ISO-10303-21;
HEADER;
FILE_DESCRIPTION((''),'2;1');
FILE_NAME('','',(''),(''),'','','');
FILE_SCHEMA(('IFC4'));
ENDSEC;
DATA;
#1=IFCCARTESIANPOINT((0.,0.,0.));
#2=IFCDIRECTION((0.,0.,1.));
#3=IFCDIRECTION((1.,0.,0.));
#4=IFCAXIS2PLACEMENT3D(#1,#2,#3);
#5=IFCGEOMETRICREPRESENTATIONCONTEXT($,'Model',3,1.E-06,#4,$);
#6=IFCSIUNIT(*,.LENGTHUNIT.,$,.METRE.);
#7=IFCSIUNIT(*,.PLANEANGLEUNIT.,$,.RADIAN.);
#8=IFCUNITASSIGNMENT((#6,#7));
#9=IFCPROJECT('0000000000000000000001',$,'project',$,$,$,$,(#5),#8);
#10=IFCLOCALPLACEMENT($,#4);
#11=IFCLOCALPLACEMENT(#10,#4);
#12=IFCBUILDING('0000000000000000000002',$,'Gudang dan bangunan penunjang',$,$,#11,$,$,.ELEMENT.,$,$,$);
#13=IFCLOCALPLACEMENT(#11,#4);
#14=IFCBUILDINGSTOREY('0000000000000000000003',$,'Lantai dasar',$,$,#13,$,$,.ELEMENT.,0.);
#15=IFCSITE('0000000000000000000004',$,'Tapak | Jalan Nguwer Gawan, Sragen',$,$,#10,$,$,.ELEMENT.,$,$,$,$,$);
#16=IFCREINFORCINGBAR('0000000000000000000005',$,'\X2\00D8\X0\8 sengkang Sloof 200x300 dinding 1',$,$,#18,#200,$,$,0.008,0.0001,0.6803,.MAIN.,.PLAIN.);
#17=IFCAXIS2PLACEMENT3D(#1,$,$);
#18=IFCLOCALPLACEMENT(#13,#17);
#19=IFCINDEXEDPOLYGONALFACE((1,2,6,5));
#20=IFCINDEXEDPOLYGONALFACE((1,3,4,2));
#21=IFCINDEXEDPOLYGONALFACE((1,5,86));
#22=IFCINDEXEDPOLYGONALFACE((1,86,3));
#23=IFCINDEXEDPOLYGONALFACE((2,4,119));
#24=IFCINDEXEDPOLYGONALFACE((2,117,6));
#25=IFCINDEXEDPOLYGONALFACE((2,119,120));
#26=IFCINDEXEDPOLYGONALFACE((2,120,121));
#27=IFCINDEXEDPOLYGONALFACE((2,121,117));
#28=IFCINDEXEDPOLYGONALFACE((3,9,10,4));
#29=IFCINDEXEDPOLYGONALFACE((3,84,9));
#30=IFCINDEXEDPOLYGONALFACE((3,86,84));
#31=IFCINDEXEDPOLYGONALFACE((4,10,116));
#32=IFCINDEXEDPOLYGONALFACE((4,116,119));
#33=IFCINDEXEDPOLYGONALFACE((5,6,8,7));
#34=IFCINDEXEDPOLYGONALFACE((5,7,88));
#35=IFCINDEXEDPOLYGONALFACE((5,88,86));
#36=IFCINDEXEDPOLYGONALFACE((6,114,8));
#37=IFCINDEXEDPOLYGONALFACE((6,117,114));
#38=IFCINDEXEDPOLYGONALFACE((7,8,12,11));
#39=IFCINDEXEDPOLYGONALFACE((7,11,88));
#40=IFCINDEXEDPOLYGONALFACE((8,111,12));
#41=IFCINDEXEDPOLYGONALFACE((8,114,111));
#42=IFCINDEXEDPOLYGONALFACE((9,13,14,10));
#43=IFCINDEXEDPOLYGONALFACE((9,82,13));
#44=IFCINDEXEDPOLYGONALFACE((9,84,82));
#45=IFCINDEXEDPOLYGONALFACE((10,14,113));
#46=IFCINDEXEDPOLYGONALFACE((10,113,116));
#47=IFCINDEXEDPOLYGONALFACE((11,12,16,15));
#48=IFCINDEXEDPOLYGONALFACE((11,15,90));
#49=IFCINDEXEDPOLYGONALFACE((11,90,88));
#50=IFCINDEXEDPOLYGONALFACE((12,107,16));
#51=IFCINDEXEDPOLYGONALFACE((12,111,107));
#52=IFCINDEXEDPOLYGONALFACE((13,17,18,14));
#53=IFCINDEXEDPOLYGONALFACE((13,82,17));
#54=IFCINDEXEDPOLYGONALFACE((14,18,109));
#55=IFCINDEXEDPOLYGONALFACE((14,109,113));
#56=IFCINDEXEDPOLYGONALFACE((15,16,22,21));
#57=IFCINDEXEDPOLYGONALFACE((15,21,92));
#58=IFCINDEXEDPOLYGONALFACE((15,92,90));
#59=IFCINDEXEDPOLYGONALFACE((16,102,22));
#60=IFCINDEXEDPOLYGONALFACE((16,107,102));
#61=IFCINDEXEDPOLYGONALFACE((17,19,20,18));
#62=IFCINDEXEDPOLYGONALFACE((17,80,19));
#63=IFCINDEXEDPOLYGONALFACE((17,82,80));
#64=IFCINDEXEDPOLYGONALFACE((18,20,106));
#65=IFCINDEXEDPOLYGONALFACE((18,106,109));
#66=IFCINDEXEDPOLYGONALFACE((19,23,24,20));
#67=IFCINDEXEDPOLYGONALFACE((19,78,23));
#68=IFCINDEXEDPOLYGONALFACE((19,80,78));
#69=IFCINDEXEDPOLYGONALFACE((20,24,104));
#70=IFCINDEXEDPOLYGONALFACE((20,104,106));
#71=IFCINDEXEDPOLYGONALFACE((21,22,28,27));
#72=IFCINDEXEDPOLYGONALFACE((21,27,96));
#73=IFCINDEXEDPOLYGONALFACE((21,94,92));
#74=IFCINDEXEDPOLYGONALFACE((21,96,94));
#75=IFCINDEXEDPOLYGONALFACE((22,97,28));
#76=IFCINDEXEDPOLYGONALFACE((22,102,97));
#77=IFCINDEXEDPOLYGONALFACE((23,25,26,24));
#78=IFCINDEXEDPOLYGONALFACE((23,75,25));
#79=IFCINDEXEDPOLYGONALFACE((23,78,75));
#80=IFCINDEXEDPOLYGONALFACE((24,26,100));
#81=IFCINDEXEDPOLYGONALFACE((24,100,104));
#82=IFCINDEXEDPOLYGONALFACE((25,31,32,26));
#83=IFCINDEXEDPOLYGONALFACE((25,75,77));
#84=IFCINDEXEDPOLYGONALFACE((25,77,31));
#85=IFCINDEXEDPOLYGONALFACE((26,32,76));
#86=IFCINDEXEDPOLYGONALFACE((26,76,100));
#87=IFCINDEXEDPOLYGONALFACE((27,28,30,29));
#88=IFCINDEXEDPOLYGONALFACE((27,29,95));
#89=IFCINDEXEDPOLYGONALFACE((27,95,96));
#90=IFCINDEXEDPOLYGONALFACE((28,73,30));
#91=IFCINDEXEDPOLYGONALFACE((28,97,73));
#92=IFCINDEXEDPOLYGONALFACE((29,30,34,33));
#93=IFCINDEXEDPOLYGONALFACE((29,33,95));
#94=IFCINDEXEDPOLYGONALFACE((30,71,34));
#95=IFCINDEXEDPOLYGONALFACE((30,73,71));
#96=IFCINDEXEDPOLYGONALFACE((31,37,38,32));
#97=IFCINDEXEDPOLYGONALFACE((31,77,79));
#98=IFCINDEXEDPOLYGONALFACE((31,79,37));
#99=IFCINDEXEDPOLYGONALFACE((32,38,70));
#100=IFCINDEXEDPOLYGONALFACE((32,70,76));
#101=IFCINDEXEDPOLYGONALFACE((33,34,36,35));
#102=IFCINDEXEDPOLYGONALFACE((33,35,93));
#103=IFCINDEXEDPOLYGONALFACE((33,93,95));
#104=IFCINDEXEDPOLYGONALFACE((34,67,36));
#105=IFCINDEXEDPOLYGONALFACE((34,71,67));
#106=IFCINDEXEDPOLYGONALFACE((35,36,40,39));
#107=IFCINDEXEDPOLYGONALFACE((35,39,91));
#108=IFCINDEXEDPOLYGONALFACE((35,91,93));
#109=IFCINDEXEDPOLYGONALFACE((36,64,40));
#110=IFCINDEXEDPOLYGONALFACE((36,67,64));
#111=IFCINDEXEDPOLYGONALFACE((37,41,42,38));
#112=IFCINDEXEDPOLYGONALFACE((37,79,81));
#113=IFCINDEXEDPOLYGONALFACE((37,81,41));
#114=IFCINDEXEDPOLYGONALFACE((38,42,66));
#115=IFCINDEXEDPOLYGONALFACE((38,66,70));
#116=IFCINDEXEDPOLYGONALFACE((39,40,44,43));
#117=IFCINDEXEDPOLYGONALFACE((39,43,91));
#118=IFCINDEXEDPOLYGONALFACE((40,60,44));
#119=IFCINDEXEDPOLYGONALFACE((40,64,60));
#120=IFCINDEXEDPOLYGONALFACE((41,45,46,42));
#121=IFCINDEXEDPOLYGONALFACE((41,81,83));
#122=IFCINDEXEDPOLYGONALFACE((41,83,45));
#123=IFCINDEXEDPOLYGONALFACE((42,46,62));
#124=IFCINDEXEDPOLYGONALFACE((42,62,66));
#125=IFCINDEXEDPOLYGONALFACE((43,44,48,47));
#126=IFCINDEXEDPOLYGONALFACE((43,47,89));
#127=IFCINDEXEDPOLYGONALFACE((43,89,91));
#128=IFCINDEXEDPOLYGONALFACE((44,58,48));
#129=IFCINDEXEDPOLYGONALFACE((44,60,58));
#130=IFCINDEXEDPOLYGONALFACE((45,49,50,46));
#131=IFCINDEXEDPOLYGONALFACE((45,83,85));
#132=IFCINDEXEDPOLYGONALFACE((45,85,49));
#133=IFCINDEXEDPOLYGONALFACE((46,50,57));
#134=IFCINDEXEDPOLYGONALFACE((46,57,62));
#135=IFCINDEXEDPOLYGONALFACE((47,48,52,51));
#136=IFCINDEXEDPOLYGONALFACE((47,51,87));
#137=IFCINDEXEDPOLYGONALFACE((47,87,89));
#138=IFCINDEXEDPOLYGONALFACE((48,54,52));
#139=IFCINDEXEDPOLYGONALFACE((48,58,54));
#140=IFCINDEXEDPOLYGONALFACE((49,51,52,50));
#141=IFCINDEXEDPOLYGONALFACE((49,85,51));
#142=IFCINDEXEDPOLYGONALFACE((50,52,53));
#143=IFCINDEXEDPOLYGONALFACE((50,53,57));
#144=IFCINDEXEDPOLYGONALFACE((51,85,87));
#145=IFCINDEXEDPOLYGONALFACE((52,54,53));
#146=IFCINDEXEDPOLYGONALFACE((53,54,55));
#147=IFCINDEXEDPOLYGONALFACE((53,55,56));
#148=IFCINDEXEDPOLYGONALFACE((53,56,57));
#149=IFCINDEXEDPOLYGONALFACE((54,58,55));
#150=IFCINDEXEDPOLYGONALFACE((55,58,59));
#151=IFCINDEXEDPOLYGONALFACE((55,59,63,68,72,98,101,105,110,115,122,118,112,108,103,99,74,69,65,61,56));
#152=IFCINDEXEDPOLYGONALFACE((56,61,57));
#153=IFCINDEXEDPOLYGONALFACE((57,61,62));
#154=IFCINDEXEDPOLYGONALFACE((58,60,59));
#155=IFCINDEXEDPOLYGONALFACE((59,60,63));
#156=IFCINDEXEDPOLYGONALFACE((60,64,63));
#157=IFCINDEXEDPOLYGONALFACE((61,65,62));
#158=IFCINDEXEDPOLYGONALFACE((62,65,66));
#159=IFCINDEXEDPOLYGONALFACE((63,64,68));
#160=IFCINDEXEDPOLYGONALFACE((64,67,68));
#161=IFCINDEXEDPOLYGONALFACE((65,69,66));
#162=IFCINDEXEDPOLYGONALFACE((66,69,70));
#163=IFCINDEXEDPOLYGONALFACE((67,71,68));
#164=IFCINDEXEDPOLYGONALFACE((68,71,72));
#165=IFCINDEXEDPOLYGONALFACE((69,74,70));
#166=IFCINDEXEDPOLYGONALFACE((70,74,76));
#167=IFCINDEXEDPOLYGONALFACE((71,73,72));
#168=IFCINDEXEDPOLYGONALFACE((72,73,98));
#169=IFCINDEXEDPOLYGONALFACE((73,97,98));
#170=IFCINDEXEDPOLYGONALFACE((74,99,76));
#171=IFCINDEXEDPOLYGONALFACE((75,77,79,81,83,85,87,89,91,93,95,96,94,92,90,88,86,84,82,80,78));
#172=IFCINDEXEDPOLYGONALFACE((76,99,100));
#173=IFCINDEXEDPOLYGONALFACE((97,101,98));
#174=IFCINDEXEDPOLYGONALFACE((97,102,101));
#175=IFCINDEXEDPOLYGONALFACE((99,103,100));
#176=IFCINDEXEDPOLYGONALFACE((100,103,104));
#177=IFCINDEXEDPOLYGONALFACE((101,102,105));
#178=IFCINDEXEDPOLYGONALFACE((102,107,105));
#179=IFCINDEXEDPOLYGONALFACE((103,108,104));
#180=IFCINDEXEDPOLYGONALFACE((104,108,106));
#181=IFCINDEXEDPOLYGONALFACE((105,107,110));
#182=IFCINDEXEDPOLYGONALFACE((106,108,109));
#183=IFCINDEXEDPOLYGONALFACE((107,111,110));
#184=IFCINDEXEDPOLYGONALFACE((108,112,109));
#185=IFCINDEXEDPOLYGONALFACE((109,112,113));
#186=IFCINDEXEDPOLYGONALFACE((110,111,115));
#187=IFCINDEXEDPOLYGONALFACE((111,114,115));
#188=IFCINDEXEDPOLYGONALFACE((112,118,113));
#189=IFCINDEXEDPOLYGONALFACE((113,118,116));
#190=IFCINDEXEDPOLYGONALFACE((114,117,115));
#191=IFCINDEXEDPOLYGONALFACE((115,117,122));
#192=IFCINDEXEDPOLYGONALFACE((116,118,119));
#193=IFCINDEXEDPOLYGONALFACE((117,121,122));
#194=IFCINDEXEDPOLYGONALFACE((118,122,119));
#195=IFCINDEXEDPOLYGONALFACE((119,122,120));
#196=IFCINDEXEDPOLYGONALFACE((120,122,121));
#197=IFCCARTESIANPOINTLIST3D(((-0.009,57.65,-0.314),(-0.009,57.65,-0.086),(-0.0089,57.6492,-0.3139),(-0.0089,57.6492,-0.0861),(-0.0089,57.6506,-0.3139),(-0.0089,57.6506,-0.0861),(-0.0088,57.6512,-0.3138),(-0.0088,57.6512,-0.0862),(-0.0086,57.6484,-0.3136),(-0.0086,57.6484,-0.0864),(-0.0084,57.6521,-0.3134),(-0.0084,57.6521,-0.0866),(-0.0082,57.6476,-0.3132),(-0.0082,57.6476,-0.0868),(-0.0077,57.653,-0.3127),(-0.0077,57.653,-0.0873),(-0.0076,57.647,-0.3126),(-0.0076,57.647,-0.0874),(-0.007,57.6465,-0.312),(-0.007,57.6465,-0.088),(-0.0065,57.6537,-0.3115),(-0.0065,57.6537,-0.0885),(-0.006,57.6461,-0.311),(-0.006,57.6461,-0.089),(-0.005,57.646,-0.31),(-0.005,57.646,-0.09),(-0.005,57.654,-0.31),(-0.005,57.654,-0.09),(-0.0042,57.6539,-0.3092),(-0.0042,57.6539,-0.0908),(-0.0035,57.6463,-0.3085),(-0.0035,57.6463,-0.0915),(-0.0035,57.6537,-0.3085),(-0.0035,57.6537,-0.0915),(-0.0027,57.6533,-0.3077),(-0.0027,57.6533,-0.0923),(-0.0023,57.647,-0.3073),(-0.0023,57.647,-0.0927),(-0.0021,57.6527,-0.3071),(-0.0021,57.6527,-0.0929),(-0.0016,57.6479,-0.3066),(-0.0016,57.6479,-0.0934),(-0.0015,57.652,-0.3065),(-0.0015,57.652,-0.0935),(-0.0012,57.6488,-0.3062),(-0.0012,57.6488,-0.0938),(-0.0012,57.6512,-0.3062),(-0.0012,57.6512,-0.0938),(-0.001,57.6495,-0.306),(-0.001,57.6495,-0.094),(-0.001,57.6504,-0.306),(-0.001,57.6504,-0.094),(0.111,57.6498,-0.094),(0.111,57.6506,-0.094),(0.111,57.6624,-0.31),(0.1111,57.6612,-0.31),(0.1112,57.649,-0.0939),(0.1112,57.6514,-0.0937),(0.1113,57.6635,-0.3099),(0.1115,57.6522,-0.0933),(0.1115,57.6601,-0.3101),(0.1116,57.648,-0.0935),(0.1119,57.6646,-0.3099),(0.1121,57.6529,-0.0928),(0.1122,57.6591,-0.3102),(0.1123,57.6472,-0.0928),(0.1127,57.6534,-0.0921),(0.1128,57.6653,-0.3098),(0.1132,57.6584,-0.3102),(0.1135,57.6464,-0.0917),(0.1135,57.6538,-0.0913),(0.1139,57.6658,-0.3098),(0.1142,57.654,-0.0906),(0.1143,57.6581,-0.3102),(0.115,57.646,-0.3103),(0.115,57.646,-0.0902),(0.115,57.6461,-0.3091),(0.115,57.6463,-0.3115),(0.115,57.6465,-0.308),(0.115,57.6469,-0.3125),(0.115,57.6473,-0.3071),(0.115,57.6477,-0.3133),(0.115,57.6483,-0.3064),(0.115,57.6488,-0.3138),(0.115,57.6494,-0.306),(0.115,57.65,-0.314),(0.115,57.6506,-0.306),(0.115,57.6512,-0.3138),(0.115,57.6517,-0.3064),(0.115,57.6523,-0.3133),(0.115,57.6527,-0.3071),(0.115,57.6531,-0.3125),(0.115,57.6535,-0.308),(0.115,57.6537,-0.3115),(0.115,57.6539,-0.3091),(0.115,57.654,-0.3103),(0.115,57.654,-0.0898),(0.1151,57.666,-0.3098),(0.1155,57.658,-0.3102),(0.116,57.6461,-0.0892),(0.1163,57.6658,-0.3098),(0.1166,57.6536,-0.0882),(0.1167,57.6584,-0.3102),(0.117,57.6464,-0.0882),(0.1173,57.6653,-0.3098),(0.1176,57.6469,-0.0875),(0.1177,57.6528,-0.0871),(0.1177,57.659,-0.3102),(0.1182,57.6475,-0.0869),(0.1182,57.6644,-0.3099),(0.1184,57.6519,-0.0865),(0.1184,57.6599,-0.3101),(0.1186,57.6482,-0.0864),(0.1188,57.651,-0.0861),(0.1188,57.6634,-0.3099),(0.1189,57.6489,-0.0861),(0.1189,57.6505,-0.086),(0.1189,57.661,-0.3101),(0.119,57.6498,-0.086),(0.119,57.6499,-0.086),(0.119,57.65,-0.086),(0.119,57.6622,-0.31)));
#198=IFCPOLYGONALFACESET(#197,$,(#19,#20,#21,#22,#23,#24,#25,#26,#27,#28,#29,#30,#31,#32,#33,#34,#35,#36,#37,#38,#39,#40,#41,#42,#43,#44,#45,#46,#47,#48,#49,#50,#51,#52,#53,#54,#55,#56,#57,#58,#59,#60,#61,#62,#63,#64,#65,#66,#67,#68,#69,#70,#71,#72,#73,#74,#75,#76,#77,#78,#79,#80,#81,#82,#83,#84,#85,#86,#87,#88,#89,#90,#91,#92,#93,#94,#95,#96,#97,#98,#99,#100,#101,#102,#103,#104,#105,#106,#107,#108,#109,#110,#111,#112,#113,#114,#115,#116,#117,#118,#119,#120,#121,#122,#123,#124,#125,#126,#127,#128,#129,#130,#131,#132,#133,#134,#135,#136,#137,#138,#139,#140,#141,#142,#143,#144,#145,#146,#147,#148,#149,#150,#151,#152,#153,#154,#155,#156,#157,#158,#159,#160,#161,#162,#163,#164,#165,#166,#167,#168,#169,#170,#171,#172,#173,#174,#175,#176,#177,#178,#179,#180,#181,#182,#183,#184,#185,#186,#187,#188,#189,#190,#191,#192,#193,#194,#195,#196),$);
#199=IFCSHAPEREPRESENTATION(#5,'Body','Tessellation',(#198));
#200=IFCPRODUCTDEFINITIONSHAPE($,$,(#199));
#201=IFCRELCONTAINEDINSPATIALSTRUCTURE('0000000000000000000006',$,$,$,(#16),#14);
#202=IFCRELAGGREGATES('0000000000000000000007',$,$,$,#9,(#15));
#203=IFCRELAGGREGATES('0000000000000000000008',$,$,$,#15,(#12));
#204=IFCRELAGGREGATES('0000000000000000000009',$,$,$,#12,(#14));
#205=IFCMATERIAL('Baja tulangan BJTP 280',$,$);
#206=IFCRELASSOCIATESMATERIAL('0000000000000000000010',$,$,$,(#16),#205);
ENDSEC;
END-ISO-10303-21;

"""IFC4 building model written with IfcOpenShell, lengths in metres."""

from ifc_helpers import new_model, entity, si_unit, origin_with_axes, place, context, project, spatial, material, element, save


model = new_model("IFC4")

# Units and contexts
model_context = context("Model", 3, precision=1e-06, world=origin_with_axes())
ifc_project = project(units=[si_unit("LENGTHUNIT", "METRE"), si_unit("PLANEANGLEUNIT", "RADIAN")], contexts=[model_context])

# Site, building, storey
site_placement = place(None, origin_with_axes())
site = spatial("IfcSite", under=ifc_project, at=site_placement, Name="Tapak | Jalan Nguwer Gawan, Sragen", CompositionType="ELEMENT")
building_placement = place(site_placement, origin_with_axes())
building = spatial("IfcBuilding", under=site, at=building_placement, Name="Gudang dan bangunan penunjang", CompositionType="ELEMENT")
storey_placement = place(building_placement, origin_with_axes())
storey = spatial("IfcBuildingStorey", under=building, at=storey_placement, Name="Lantai dasar", CompositionType="ELEMENT", Elevation=0.0)

# Shared definitions
placement = place(None, origin_with_axes())

# Reinforcing bar
ifc_material_1 = material(Name="Baja tulangan BJTP 280")
element("IfcReinforcingBar", 1, at=placement, inside=storey, material=ifc_material_1, Name="Ø8 sengkang Sloof 200x300 dinding 1", BarLength=0.6803, BarSurface="PLAIN", CrossSectionArea=0.0001, NominalDiameter=0.008, PredefinedType="MAIN", context=model_context, shape_type="AdvancedSweptSolid", body=[
    entity("IfcSweptDiskSolid", entity("IfcPolyline", [entity("IfcCartesianPoint", [0.115, 57.65, -0.31]), entity("IfcCartesianPoint", [-0.005, 57.65, -0.31]), entity("IfcCartesianPoint", [-0.005, 57.65, -0.09]), entity("IfcCartesianPoint", [0.115, 57.65, -0.09]), entity("IfcCartesianPoint", [0.115, 57.662, -0.31])]), 0.004),
])

save(model, "model.ifc")
